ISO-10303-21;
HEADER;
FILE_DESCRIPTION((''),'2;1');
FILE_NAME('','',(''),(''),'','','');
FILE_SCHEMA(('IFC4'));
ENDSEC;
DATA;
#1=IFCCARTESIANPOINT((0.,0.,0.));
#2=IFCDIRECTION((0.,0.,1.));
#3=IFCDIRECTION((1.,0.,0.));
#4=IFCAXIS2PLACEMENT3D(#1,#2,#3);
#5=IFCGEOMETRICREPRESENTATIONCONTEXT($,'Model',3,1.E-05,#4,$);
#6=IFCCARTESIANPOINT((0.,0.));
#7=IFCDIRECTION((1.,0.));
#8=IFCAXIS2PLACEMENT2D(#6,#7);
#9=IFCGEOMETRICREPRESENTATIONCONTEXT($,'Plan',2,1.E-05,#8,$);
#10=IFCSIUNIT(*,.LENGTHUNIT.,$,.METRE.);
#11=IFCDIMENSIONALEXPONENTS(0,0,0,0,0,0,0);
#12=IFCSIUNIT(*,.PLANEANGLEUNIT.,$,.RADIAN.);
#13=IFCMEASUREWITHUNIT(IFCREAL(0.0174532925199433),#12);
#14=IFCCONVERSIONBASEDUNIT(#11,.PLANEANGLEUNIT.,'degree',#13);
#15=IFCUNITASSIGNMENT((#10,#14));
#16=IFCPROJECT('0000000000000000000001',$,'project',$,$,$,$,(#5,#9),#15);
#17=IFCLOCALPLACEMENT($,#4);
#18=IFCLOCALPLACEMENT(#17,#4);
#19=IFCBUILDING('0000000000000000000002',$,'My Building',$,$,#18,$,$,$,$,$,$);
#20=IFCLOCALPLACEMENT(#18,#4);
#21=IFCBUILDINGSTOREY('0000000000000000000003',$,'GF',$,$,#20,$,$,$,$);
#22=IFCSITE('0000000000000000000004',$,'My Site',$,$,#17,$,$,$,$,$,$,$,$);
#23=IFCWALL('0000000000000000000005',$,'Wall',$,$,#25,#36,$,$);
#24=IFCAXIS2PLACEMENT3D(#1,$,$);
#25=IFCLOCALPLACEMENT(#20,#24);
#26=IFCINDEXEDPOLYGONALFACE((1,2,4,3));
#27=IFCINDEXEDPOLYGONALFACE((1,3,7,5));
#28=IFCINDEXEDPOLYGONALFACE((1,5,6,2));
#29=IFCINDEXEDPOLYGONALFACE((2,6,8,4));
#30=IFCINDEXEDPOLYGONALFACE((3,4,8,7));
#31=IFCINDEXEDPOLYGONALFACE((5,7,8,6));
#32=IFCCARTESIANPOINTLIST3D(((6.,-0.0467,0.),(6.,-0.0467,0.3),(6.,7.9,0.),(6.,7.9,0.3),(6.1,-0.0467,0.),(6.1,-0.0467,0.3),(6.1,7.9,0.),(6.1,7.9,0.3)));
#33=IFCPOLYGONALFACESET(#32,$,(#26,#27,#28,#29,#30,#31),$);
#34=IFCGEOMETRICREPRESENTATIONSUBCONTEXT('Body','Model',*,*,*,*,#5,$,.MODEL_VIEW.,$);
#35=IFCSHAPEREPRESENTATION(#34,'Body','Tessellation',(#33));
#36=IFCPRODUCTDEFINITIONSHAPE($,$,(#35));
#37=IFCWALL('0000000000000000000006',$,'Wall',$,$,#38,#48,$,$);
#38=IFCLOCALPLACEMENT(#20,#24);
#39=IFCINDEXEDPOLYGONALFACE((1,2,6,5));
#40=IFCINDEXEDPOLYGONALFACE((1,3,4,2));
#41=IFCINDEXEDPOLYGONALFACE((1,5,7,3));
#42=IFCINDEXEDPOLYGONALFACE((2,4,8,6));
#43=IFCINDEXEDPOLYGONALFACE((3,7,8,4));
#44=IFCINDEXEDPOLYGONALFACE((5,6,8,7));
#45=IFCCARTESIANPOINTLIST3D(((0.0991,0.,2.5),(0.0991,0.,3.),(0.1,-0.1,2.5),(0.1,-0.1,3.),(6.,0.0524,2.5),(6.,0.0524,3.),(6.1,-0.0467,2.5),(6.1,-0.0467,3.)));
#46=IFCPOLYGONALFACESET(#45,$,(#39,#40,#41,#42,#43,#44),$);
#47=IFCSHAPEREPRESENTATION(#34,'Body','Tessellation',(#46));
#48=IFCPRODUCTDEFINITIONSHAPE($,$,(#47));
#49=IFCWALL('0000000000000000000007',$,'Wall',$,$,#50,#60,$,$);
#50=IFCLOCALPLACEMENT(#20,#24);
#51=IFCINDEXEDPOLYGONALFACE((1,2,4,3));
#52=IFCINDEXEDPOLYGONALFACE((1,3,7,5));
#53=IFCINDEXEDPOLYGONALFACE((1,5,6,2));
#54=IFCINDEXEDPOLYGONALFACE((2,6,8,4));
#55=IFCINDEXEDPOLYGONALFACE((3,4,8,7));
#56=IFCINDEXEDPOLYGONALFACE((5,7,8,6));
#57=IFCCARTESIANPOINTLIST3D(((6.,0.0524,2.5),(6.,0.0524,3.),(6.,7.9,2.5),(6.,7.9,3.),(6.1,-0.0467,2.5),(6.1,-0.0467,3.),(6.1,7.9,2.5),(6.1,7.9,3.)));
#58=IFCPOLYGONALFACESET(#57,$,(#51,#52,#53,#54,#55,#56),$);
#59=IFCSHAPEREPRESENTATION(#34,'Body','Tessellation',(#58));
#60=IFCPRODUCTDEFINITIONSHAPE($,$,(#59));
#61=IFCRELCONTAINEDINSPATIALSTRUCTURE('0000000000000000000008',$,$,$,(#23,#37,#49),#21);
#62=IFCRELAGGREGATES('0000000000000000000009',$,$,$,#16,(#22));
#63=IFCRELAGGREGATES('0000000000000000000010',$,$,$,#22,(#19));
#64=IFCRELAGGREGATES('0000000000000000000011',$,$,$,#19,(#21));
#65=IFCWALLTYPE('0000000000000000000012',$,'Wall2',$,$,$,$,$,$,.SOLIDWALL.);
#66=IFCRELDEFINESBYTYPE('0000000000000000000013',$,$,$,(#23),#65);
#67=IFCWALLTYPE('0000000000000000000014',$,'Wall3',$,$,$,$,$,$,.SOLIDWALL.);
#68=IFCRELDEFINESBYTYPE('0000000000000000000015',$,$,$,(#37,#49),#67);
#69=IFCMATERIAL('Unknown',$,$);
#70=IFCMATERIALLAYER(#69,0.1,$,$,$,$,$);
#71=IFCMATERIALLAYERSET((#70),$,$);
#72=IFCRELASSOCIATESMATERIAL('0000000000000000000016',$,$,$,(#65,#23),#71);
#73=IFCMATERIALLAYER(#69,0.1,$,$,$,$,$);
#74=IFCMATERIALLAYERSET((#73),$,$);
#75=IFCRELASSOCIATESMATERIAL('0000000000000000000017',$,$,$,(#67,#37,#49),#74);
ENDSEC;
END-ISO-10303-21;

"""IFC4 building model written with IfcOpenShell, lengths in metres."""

from ifc_helpers import new_model, entity, si_unit, converted_unit, frame, origin_with_axes, origin_2d_with_axis, place, context, subcontext, project, spatial, line, indexed_curve, outline, extrude, material, layer, layer_set, layer_usage, type_object, element, save


model = new_model("IFC4")

# Units and contexts
model_context = context("Model", 3, precision=1e-05, world=origin_with_axes())
plan_context = context("Plan", 2, precision=1e-05, world=origin_2d_with_axis())
body_context_1 = subcontext(model_context, "Body", "Model", "MODEL_VIEW")
ifc_project = project(units=[si_unit("LENGTHUNIT", "METRE"), converted_unit("PLANEANGLEUNIT", "degree", entity("IfcReal", 0.0174532925199433), si_unit("PLANEANGLEUNIT", "RADIAN"), dimensions=[0, 0, 0, 0, 0, 0, 0])], contexts=[model_context, plan_context])

# Site, building, storey
site_placement = place(None, origin_with_axes())
site = spatial("IfcSite", under=ifc_project, at=site_placement, Name="My Site")
building_placement = place(site_placement, origin_with_axes())
building = spatial("IfcBuilding", under=site, at=building_placement, Name="My Building")
storey_placement = place(building_placement, origin_with_axes())
storey = spatial("IfcBuildingStorey", under=building, at=storey_placement, Name="GF")

# Shared definitions
ifc_material = material(Name="Unknown")

# Walls
ifc_layer_1 = layer(ifc_material, 0.1)
ifc_layer_set_1 = layer_set([ifc_layer_1])
wall_type_1 = type_object("IfcWallType", Name="Wall2", PredefinedType="SOLIDWALL", material=ifc_layer_set_1)
ifc_layer_usage_1 = layer_usage(ifc_layer_set_1, "AXIS2", "POSITIVE", 0.0)
wall_1_placement = place(storey_placement, frame((6.0, 7.9, 0.0), z_axis=(0.0, 0.0, 1.0), x_axis=(0.0, -1.0, 0.0)))
element("IfcWall", 1, at=wall_1_placement, inside=storey, type_object=wall_type_1, material=ifc_layer_usage_1, Name="Wall", context=body_context_1, shape_type="SweptSolid", body=[
    extrude(outline(indexed_curve([(0.0, 0.0), (0.0, 0.1), (7.9467, 0.1), (7.9467, 0.0)], segments=[line(1, 2, 3, 4, 1)])), origin_with_axes(), (0.0, 0.0, 1.0), 0.3),
])
ifc_layer_2 = layer(ifc_material, 0.1)
ifc_layer_set_2 = layer_set([ifc_layer_2])
ifc_layer_usage_2 = layer_usage(ifc_layer_set_2, "AXIS2", "POSITIVE", 0.0)
wall_type_2 = type_object("IfcWallType", Name="Wall3", PredefinedType="SOLIDWALL", material=ifc_layer_set_2)
wall_2_placement = place(storey_placement, frame((0.1, -0.1, 2.5), z_axis=(0.0, 0.0, 1.0), x_axis=(0.999961, 0.008884, 0.0)))
element("IfcWall", 2, at=wall_2_placement, inside=storey, type_object=wall_type_2, material=ifc_layer_usage_2, Name="Wall", context=body_context_1, shape_type="SweptSolid", body=[
    extrude(outline(indexed_curve([(0.0, 0.0), (0.0, 0.1), (5.9011, 0.1), (6.0002, 0.0)], segments=[line(1, 2, 3, 4, 1)])), origin_with_axes(), (0.0, 0.0, 1.0), 0.5),
])
ifc_layer_usage_3 = layer_usage(ifc_layer_set_2, "AXIS2", "POSITIVE", 0.0)
wall_3_placement = place(storey_placement, frame((6.1, -0.0467, 2.5), z_axis=(0.0, 0.0, 1.0), x_axis=(0.0, 1.0, 0.0)))
element("IfcWall", 3, at=wall_3_placement, inside=storey, type_object=wall_type_2, material=ifc_layer_usage_3, Name="Wall", context=body_context_1, shape_type="SweptSolid", body=[
    extrude(outline(indexed_curve([(0.0, 0.0), (0.0991, 0.1), (7.9467, 0.1), (7.9467, 0.0)], segments=[line(1, 2, 3, 4, 1)])), origin_with_axes(), (0.0, 0.0, 1.0), 0.5),
])

save(model, "model.ifc")
